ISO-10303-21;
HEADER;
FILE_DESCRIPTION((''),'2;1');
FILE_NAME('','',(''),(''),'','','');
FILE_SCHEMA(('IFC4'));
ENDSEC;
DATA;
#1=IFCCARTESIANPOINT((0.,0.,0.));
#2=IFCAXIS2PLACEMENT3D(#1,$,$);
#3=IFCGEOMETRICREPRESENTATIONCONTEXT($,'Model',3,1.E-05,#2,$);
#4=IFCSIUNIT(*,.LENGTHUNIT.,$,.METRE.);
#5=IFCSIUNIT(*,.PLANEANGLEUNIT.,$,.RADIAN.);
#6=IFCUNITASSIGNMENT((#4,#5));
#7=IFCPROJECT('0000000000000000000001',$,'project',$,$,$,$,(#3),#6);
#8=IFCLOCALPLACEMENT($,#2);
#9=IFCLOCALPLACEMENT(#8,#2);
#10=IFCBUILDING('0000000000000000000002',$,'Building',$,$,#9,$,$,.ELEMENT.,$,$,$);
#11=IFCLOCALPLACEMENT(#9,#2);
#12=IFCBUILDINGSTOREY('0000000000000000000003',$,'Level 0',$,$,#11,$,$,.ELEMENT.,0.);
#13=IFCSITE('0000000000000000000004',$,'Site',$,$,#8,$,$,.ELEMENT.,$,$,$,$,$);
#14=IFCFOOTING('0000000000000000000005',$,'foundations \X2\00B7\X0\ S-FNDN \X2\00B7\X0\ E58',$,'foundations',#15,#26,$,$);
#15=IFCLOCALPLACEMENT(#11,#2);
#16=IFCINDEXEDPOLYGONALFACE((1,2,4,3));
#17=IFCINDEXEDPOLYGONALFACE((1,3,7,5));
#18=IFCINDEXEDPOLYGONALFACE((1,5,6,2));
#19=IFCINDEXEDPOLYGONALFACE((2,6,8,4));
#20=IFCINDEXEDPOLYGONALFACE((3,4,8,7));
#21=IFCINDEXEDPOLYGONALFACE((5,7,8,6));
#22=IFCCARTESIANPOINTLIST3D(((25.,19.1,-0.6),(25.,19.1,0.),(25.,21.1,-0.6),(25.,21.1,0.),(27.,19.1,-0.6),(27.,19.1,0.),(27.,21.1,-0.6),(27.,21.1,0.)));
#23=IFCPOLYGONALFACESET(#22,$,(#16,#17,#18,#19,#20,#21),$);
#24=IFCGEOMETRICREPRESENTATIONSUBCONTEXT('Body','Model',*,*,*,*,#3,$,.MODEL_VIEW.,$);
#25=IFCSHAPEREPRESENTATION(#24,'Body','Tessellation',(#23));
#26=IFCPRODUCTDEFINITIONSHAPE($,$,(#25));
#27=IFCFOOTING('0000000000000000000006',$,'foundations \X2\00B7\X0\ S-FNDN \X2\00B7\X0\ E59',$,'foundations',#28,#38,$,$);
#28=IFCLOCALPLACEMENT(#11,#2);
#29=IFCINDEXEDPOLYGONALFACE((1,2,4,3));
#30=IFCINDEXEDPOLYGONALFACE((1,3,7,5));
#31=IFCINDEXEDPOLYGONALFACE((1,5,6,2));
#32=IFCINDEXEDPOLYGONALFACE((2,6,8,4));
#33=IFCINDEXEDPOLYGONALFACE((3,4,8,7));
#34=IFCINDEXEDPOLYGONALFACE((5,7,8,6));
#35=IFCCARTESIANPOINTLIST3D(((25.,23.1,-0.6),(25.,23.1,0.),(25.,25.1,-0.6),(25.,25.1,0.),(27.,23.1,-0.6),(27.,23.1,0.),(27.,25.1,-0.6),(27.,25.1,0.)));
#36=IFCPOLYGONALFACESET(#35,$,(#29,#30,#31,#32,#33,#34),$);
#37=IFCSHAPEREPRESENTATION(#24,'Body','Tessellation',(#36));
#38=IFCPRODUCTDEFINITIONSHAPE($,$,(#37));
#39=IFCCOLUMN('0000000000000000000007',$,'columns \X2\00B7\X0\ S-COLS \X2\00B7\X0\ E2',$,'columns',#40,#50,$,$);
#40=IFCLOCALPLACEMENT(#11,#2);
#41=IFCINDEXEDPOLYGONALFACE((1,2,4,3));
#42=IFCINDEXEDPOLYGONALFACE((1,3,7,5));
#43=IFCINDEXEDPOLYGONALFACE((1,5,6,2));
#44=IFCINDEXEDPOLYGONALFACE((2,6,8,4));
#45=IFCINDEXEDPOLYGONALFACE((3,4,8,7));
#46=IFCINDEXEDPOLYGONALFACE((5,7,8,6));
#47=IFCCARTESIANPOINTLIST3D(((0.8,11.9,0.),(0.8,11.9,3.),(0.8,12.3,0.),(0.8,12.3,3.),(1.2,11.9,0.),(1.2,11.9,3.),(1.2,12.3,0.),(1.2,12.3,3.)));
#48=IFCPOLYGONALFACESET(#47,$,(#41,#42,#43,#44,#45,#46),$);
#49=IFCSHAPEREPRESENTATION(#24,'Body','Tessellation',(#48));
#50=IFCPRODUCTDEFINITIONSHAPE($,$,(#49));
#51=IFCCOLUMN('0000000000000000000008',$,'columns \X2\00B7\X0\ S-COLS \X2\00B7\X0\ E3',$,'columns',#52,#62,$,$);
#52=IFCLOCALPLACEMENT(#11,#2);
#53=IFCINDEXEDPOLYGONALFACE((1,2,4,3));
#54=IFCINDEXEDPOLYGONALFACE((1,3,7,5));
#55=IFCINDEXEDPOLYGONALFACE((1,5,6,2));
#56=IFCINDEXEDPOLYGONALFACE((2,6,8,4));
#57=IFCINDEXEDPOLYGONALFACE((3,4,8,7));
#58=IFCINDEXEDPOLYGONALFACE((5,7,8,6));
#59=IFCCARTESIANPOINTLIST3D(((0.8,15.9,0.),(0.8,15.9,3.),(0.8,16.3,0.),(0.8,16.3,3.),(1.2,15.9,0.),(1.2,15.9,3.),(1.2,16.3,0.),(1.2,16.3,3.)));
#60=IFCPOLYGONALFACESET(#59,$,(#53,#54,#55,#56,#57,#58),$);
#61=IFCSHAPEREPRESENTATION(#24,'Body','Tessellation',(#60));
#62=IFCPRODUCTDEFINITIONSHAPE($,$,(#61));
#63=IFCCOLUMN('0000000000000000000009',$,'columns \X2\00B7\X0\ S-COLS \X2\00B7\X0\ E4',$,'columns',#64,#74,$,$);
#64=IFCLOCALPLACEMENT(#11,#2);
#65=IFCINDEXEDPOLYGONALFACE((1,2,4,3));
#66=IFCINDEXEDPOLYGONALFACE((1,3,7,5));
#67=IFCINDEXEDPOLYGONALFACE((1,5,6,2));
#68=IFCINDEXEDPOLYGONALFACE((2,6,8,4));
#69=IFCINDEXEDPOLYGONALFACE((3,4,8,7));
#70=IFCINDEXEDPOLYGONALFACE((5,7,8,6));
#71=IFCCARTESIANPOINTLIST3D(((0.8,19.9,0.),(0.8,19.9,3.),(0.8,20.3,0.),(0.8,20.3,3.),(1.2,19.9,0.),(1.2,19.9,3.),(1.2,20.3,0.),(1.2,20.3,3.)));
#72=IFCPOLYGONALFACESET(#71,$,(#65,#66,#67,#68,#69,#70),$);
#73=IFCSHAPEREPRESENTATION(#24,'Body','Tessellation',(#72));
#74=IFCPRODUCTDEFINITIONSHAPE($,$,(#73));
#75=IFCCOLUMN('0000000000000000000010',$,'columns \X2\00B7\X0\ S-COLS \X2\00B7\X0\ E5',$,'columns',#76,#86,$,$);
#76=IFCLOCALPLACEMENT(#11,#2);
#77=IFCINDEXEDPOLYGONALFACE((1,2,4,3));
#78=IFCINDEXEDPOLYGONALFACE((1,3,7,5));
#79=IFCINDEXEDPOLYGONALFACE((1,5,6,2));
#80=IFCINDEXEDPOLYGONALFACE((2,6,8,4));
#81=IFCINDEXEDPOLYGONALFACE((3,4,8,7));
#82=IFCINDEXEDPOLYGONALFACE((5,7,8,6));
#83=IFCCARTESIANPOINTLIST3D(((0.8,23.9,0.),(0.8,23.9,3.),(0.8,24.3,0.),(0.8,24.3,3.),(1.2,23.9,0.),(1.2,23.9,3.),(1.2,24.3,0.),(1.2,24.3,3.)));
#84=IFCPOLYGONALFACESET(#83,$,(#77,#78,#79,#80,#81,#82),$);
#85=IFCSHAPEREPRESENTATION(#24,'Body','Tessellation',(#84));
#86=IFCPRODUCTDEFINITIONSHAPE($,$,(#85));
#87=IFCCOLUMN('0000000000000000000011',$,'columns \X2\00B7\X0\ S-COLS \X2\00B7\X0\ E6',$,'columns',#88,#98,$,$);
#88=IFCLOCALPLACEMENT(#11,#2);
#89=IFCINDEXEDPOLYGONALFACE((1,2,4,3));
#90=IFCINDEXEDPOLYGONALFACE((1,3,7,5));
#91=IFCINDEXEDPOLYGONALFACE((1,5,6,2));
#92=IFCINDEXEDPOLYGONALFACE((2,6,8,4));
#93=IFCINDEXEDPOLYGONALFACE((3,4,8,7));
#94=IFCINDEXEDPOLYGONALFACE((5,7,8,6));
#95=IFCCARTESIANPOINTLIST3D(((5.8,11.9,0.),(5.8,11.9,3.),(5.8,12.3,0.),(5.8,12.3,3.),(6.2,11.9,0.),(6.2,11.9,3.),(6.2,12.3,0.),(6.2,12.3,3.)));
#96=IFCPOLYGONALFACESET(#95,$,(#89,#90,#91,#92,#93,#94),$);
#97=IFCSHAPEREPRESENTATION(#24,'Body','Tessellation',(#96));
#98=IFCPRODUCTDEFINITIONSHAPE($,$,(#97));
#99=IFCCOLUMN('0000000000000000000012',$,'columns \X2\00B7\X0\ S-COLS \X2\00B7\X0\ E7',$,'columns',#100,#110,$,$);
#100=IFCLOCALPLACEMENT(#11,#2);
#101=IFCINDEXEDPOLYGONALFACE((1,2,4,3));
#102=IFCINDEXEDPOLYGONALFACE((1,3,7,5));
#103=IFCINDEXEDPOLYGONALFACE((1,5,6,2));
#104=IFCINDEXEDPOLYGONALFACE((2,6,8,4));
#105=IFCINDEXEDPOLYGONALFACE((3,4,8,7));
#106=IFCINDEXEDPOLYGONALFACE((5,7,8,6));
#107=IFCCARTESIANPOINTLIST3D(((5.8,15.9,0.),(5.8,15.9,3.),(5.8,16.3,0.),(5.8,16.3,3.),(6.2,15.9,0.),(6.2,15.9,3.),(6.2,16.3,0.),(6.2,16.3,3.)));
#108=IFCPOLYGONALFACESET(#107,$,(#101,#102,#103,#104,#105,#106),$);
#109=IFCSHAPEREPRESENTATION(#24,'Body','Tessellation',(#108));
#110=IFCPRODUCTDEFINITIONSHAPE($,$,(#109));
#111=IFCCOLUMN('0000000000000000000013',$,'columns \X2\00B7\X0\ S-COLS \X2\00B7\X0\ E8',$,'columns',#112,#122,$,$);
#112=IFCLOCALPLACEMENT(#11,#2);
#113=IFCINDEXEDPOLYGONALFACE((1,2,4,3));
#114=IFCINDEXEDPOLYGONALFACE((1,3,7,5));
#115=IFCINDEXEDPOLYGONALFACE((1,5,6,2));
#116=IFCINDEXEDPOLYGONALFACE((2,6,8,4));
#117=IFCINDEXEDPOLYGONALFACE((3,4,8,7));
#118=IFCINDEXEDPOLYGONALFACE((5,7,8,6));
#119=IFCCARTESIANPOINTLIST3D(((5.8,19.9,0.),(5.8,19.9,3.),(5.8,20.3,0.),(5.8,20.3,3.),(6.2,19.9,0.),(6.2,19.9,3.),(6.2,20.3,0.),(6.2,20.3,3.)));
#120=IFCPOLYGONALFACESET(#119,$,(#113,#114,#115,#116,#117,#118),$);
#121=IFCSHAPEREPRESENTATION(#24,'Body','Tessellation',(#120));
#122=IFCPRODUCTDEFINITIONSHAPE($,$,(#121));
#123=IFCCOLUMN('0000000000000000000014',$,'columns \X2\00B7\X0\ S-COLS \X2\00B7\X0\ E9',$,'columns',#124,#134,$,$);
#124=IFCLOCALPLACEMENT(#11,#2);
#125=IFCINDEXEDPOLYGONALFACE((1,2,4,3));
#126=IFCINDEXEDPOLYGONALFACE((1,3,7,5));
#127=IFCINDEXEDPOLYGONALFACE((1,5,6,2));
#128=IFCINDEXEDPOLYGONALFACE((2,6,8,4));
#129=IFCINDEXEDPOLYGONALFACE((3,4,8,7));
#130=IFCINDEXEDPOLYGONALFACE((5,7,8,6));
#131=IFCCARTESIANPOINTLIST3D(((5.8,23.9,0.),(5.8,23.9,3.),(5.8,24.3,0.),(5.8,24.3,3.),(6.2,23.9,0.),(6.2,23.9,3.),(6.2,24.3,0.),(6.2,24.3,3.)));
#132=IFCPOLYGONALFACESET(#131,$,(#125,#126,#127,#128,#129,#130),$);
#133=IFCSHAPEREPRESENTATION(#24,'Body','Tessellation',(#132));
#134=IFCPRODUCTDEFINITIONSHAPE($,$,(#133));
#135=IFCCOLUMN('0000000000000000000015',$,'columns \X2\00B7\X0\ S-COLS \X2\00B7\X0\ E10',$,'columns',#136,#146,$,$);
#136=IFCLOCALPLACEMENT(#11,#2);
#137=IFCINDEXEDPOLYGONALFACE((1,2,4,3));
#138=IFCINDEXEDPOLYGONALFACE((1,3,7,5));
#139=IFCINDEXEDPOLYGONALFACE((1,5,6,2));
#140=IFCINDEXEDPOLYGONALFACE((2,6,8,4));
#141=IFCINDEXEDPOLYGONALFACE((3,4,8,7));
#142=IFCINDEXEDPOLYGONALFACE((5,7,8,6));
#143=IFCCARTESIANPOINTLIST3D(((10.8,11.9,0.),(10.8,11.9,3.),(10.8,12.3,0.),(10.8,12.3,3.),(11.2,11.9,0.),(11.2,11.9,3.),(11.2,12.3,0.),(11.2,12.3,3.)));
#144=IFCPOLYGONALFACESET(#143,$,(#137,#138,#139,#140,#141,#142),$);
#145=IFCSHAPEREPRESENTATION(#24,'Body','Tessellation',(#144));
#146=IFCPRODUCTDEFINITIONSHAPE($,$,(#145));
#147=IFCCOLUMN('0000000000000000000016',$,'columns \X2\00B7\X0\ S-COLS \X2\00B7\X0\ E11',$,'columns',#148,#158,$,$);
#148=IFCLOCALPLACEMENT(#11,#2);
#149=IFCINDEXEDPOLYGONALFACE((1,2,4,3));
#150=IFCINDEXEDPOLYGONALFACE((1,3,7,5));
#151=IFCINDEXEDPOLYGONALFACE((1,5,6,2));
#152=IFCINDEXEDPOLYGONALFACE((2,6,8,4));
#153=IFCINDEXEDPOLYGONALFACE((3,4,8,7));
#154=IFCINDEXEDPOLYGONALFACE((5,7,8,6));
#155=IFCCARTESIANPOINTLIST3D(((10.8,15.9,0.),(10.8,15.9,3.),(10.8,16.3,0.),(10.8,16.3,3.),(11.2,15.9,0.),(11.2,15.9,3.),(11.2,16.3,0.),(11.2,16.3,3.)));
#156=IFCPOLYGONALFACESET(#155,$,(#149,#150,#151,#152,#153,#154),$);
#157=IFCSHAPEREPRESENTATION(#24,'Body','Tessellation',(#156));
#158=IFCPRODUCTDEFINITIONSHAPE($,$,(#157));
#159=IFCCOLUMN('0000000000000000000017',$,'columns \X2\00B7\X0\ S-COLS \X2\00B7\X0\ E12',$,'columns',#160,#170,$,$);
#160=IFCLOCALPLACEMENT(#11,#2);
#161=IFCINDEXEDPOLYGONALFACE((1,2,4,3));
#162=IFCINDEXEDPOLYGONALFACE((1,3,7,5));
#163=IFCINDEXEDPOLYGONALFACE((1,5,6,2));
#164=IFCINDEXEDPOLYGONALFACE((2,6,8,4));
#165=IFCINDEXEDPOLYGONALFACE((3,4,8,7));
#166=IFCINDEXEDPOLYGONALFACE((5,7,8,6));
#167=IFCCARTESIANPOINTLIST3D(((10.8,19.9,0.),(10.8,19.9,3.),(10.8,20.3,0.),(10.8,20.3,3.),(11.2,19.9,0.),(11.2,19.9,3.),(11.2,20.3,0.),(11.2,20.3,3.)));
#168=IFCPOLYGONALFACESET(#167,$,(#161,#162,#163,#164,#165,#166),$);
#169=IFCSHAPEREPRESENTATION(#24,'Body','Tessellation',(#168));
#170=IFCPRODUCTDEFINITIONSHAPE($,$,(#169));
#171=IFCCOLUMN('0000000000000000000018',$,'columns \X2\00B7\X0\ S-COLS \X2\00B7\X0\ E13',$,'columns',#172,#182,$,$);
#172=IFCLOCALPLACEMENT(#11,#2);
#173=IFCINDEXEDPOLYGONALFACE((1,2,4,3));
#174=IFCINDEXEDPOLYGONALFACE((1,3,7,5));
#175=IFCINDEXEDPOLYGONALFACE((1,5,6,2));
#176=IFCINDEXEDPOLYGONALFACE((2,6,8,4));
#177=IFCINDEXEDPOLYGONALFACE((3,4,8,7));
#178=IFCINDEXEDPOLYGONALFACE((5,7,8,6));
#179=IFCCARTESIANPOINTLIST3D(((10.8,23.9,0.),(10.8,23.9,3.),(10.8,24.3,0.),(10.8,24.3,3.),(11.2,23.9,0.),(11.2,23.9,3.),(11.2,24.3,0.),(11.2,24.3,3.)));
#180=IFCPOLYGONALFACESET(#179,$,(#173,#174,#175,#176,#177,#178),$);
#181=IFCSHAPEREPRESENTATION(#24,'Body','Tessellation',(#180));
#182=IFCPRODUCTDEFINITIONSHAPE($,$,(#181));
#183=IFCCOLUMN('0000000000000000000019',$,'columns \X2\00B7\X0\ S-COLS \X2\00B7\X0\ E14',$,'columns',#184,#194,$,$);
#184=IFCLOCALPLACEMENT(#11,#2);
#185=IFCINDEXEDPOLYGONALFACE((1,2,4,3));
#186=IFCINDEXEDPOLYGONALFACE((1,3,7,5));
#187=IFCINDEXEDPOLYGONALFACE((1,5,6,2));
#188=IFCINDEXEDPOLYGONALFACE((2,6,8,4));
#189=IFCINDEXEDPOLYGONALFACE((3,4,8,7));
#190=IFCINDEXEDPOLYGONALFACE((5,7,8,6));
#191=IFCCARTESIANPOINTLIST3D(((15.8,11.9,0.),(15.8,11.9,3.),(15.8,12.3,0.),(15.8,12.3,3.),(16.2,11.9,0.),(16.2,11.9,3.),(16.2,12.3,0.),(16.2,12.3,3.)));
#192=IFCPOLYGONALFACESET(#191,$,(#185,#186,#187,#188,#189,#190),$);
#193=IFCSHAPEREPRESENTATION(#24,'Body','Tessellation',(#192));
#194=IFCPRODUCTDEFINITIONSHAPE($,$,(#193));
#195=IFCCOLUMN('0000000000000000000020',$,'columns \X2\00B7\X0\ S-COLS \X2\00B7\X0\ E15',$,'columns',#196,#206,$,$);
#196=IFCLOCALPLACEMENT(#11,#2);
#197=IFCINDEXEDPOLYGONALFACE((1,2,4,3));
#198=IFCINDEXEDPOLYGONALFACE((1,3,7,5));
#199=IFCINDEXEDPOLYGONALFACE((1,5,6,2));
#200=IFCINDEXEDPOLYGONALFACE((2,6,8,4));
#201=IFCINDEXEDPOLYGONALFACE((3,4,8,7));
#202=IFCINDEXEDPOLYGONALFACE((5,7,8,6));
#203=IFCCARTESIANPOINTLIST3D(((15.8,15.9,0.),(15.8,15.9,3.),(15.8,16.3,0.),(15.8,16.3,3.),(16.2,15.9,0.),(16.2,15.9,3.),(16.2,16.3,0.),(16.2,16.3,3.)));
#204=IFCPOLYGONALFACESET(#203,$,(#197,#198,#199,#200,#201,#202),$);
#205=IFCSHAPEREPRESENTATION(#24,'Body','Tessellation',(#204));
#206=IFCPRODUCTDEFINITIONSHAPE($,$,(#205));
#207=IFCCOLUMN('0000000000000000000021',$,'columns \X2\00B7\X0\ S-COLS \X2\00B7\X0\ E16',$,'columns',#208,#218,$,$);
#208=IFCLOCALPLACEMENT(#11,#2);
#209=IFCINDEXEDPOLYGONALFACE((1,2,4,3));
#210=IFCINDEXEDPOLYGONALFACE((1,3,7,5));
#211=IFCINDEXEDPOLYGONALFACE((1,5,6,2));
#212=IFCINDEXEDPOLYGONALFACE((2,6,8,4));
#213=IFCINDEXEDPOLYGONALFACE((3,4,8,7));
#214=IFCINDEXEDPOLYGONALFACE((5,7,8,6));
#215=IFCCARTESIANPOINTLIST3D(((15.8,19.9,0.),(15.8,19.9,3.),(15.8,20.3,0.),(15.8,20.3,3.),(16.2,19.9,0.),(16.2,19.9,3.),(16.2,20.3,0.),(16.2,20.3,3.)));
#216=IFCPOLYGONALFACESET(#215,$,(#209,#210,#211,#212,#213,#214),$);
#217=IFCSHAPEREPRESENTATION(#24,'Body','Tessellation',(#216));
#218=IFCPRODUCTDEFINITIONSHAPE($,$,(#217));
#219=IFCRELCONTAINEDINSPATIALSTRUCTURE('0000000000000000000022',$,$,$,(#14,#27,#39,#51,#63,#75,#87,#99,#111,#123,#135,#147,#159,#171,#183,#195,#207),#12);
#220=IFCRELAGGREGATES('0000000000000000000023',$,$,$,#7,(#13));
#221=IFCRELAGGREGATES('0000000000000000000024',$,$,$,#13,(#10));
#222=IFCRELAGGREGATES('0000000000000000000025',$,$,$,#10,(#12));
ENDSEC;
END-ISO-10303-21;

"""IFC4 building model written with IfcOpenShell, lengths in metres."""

from ifc_helpers import new_model, si_unit, frame, origin, place, context, subcontext, project, spatial, polyline, outline, extrude, element, save


model = new_model("IFC4")

# Units and contexts
model_context = context("Model", 3, precision=1e-05, world=origin())
body_context = subcontext(model_context, "Body", "Model", "MODEL_VIEW")
ifc_project = project(units=[si_unit("LENGTHUNIT", "METRE"), si_unit("PLANEANGLEUNIT", "RADIAN")], contexts=[model_context])

# Site, building, storey
site_placement = place(None, origin())
site = spatial("IfcSite", under=ifc_project, at=site_placement, Name="Site", CompositionType="ELEMENT")
building_placement = place(site_placement, origin())
building = spatial("IfcBuilding", under=site, at=building_placement, Name="Building", CompositionType="ELEMENT")
storey_placement = place(building_placement, origin())
storey = spatial("IfcBuildingStorey", under=building, at=storey_placement, Name="Level 0", CompositionType="ELEMENT", Elevation=0.0)

# Footings
footing_1_placement = place(storey_placement, frame((0.0, 0.0, -0.6)))
element("IfcFooting", 1, at=footing_1_placement, inside=storey, Name="foundations · S-FNDN · E58", ObjectType="foundations", context=body_context, shape_type="SweptSolid", body=[
    extrude(outline(polyline([(25.0, 19.1), (27.0, 19.1), (27.0, 21.1), (25.0, 21.1), (25.0, 19.1)])), origin(), (0.0, 0.0, 1.0), 0.6),
])
footing_2_placement = place(storey_placement, frame((0.0, 0.0, -0.6)))
element("IfcFooting", 2, at=footing_2_placement, inside=storey, Name="foundations · S-FNDN · E59", ObjectType="foundations", context=body_context, shape_type="SweptSolid", body=[
    extrude(outline(polyline([(25.0, 23.1), (27.0, 23.1), (27.0, 25.1), (25.0, 25.1), (25.0, 23.1)])), origin(), (0.0, 0.0, 1.0), 0.6),
])

# Columns
column_1_placement = place(storey_placement, origin())
element("IfcColumn", 3, at=column_1_placement, inside=storey, Name="columns · S-COLS · E2", ObjectType="columns", context=body_context, shape_type="SweptSolid", body=[
    extrude(outline(polyline([(0.8, 11.9), (1.2, 11.9), (1.2, 12.3), (0.8, 12.3), (0.8, 11.9)])), origin(), (0.0, 0.0, 1.0), 3.0),
])
column_2_placement = place(storey_placement, origin())
element("IfcColumn", 4, at=column_2_placement, inside=storey, Name="columns · S-COLS · E3", ObjectType="columns", context=body_context, shape_type="SweptSolid", body=[
    extrude(outline(polyline([(0.8, 15.9), (1.2, 15.9), (1.2, 16.3), (0.8, 16.3), (0.8, 15.9)])), origin(), (0.0, 0.0, 1.0), 3.0),
])
column_3_placement = place(storey_placement, origin())
element("IfcColumn", 5, at=column_3_placement, inside=storey, Name="columns · S-COLS · E4", ObjectType="columns", context=body_context, shape_type="SweptSolid", body=[
    extrude(outline(polyline([(0.8, 19.9), (1.2, 19.9), (1.2, 20.3), (0.8, 20.3), (0.8, 19.9)])), origin(), (0.0, 0.0, 1.0), 3.0),
])
column_4_placement = place(storey_placement, origin())
element("IfcColumn", 6, at=column_4_placement, inside=storey, Name="columns · S-COLS · E5", ObjectType="columns", context=body_context, shape_type="SweptSolid", body=[
    extrude(outline(polyline([(0.8, 23.9), (1.2, 23.9), (1.2, 24.3), (0.8, 24.3), (0.8, 23.9)])), origin(), (0.0, 0.0, 1.0), 3.0),
])
column_5_placement = place(storey_placement, origin())
element("IfcColumn", 7, at=column_5_placement, inside=storey, Name="columns · S-COLS · E6", ObjectType="columns", context=body_context, shape_type="SweptSolid", body=[
    extrude(outline(polyline([(5.8, 11.9), (6.2, 11.9), (6.2, 12.3), (5.8, 12.3), (5.8, 11.9)])), origin(), (0.0, 0.0, 1.0), 3.0),
])
column_6_placement = place(storey_placement, origin())
element("IfcColumn", 8, at=column_6_placement, inside=storey, Name="columns · S-COLS · E7", ObjectType="columns", context=body_context, shape_type="SweptSolid", body=[
    extrude(outline(polyline([(5.8, 15.9), (6.2, 15.9), (6.2, 16.3), (5.8, 16.3), (5.8, 15.9)])), origin(), (0.0, 0.0, 1.0), 3.0),
])
column_7_placement = place(storey_placement, origin())
element("IfcColumn", 9, at=column_7_placement, inside=storey, Name="columns · S-COLS · E8", ObjectType="columns", context=body_context, shape_type="SweptSolid", body=[
    extrude(outline(polyline([(5.8, 19.9), (6.2, 19.9), (6.2, 20.3), (5.8, 20.3), (5.8, 19.9)])), origin(), (0.0, 0.0, 1.0), 3.0),
])
column_8_placement = place(storey_placement, origin())
element("IfcColumn", 10, at=column_8_placement, inside=storey, Name="columns · S-COLS · E9", ObjectType="columns", context=body_context, shape_type="SweptSolid", body=[
    extrude(outline(polyline([(5.8, 23.9), (6.2, 23.9), (6.2, 24.3), (5.8, 24.3), (5.8, 23.9)])), origin(), (0.0, 0.0, 1.0), 3.0),
])
column_9_placement = place(storey_placement, origin())
element("IfcColumn", 11, at=column_9_placement, inside=storey, Name="columns · S-COLS · E10", ObjectType="columns", context=body_context, shape_type="SweptSolid", body=[
    extrude(outline(polyline([(10.8, 11.9), (11.2, 11.9), (11.2, 12.3), (10.8, 12.3), (10.8, 11.9)])), origin(), (0.0, 0.0, 1.0), 3.0),
])
column_10_placement = place(storey_placement, origin())
element("IfcColumn", 12, at=column_10_placement, inside=storey, Name="columns · S-COLS · E11", ObjectType="columns", context=body_context, shape_type="SweptSolid", body=[
    extrude(outline(polyline([(10.8, 15.9), (11.2, 15.9), (11.2, 16.3), (10.8, 16.3), (10.8, 15.9)])), origin(), (0.0, 0.0, 1.0), 3.0),
])
column_11_placement = place(storey_placement, origin())
element("IfcColumn", 13, at=column_11_placement, inside=storey, Name="columns · S-COLS · E12", ObjectType="columns", context=body_context, shape_type="SweptSolid", body=[
    extrude(outline(polyline([(10.8, 19.9), (11.2, 19.9), (11.2, 20.3), (10.8, 20.3), (10.8, 19.9)])), origin(), (0.0, 0.0, 1.0), 3.0),
])
column_12_placement = place(storey_placement, origin())
element("IfcColumn", 14, at=column_12_placement, inside=storey, Name="columns · S-COLS · E13", ObjectType="columns", context=body_context, shape_type="SweptSolid", body=[
    extrude(outline(polyline([(10.8, 23.9), (11.2, 23.9), (11.2, 24.3), (10.8, 24.3), (10.8, 23.9)])), origin(), (0.0, 0.0, 1.0), 3.0),
])
column_13_placement = place(storey_placement, origin())
element("IfcColumn", 15, at=column_13_placement, inside=storey, Name="columns · S-COLS · E14", ObjectType="columns", context=body_context, shape_type="SweptSolid", body=[
    extrude(outline(polyline([(15.8, 11.9), (16.2, 11.9), (16.2, 12.3), (15.8, 12.3), (15.8, 11.9)])), origin(), (0.0, 0.0, 1.0), 3.0),
])
column_14_placement = place(storey_placement, origin())
element("IfcColumn", 16, at=column_14_placement, inside=storey, Name="columns · S-COLS · E15", ObjectType="columns", context=body_context, shape_type="SweptSolid", body=[
    extrude(outline(polyline([(15.8, 15.9), (16.2, 15.9), (16.2, 16.3), (15.8, 16.3), (15.8, 15.9)])), origin(), (0.0, 0.0, 1.0), 3.0),
])
column_15_placement = place(storey_placement, origin())
element("IfcColumn", 17, at=column_15_placement, inside=storey, Name="columns · S-COLS · E16", ObjectType="columns", context=body_context, shape_type="SweptSolid", body=[
    extrude(outline(polyline([(15.8, 19.9), (16.2, 19.9), (16.2, 20.3), (15.8, 20.3), (15.8, 19.9)])), origin(), (0.0, 0.0, 1.0), 3.0),
])

save(model, "model.ifc")
